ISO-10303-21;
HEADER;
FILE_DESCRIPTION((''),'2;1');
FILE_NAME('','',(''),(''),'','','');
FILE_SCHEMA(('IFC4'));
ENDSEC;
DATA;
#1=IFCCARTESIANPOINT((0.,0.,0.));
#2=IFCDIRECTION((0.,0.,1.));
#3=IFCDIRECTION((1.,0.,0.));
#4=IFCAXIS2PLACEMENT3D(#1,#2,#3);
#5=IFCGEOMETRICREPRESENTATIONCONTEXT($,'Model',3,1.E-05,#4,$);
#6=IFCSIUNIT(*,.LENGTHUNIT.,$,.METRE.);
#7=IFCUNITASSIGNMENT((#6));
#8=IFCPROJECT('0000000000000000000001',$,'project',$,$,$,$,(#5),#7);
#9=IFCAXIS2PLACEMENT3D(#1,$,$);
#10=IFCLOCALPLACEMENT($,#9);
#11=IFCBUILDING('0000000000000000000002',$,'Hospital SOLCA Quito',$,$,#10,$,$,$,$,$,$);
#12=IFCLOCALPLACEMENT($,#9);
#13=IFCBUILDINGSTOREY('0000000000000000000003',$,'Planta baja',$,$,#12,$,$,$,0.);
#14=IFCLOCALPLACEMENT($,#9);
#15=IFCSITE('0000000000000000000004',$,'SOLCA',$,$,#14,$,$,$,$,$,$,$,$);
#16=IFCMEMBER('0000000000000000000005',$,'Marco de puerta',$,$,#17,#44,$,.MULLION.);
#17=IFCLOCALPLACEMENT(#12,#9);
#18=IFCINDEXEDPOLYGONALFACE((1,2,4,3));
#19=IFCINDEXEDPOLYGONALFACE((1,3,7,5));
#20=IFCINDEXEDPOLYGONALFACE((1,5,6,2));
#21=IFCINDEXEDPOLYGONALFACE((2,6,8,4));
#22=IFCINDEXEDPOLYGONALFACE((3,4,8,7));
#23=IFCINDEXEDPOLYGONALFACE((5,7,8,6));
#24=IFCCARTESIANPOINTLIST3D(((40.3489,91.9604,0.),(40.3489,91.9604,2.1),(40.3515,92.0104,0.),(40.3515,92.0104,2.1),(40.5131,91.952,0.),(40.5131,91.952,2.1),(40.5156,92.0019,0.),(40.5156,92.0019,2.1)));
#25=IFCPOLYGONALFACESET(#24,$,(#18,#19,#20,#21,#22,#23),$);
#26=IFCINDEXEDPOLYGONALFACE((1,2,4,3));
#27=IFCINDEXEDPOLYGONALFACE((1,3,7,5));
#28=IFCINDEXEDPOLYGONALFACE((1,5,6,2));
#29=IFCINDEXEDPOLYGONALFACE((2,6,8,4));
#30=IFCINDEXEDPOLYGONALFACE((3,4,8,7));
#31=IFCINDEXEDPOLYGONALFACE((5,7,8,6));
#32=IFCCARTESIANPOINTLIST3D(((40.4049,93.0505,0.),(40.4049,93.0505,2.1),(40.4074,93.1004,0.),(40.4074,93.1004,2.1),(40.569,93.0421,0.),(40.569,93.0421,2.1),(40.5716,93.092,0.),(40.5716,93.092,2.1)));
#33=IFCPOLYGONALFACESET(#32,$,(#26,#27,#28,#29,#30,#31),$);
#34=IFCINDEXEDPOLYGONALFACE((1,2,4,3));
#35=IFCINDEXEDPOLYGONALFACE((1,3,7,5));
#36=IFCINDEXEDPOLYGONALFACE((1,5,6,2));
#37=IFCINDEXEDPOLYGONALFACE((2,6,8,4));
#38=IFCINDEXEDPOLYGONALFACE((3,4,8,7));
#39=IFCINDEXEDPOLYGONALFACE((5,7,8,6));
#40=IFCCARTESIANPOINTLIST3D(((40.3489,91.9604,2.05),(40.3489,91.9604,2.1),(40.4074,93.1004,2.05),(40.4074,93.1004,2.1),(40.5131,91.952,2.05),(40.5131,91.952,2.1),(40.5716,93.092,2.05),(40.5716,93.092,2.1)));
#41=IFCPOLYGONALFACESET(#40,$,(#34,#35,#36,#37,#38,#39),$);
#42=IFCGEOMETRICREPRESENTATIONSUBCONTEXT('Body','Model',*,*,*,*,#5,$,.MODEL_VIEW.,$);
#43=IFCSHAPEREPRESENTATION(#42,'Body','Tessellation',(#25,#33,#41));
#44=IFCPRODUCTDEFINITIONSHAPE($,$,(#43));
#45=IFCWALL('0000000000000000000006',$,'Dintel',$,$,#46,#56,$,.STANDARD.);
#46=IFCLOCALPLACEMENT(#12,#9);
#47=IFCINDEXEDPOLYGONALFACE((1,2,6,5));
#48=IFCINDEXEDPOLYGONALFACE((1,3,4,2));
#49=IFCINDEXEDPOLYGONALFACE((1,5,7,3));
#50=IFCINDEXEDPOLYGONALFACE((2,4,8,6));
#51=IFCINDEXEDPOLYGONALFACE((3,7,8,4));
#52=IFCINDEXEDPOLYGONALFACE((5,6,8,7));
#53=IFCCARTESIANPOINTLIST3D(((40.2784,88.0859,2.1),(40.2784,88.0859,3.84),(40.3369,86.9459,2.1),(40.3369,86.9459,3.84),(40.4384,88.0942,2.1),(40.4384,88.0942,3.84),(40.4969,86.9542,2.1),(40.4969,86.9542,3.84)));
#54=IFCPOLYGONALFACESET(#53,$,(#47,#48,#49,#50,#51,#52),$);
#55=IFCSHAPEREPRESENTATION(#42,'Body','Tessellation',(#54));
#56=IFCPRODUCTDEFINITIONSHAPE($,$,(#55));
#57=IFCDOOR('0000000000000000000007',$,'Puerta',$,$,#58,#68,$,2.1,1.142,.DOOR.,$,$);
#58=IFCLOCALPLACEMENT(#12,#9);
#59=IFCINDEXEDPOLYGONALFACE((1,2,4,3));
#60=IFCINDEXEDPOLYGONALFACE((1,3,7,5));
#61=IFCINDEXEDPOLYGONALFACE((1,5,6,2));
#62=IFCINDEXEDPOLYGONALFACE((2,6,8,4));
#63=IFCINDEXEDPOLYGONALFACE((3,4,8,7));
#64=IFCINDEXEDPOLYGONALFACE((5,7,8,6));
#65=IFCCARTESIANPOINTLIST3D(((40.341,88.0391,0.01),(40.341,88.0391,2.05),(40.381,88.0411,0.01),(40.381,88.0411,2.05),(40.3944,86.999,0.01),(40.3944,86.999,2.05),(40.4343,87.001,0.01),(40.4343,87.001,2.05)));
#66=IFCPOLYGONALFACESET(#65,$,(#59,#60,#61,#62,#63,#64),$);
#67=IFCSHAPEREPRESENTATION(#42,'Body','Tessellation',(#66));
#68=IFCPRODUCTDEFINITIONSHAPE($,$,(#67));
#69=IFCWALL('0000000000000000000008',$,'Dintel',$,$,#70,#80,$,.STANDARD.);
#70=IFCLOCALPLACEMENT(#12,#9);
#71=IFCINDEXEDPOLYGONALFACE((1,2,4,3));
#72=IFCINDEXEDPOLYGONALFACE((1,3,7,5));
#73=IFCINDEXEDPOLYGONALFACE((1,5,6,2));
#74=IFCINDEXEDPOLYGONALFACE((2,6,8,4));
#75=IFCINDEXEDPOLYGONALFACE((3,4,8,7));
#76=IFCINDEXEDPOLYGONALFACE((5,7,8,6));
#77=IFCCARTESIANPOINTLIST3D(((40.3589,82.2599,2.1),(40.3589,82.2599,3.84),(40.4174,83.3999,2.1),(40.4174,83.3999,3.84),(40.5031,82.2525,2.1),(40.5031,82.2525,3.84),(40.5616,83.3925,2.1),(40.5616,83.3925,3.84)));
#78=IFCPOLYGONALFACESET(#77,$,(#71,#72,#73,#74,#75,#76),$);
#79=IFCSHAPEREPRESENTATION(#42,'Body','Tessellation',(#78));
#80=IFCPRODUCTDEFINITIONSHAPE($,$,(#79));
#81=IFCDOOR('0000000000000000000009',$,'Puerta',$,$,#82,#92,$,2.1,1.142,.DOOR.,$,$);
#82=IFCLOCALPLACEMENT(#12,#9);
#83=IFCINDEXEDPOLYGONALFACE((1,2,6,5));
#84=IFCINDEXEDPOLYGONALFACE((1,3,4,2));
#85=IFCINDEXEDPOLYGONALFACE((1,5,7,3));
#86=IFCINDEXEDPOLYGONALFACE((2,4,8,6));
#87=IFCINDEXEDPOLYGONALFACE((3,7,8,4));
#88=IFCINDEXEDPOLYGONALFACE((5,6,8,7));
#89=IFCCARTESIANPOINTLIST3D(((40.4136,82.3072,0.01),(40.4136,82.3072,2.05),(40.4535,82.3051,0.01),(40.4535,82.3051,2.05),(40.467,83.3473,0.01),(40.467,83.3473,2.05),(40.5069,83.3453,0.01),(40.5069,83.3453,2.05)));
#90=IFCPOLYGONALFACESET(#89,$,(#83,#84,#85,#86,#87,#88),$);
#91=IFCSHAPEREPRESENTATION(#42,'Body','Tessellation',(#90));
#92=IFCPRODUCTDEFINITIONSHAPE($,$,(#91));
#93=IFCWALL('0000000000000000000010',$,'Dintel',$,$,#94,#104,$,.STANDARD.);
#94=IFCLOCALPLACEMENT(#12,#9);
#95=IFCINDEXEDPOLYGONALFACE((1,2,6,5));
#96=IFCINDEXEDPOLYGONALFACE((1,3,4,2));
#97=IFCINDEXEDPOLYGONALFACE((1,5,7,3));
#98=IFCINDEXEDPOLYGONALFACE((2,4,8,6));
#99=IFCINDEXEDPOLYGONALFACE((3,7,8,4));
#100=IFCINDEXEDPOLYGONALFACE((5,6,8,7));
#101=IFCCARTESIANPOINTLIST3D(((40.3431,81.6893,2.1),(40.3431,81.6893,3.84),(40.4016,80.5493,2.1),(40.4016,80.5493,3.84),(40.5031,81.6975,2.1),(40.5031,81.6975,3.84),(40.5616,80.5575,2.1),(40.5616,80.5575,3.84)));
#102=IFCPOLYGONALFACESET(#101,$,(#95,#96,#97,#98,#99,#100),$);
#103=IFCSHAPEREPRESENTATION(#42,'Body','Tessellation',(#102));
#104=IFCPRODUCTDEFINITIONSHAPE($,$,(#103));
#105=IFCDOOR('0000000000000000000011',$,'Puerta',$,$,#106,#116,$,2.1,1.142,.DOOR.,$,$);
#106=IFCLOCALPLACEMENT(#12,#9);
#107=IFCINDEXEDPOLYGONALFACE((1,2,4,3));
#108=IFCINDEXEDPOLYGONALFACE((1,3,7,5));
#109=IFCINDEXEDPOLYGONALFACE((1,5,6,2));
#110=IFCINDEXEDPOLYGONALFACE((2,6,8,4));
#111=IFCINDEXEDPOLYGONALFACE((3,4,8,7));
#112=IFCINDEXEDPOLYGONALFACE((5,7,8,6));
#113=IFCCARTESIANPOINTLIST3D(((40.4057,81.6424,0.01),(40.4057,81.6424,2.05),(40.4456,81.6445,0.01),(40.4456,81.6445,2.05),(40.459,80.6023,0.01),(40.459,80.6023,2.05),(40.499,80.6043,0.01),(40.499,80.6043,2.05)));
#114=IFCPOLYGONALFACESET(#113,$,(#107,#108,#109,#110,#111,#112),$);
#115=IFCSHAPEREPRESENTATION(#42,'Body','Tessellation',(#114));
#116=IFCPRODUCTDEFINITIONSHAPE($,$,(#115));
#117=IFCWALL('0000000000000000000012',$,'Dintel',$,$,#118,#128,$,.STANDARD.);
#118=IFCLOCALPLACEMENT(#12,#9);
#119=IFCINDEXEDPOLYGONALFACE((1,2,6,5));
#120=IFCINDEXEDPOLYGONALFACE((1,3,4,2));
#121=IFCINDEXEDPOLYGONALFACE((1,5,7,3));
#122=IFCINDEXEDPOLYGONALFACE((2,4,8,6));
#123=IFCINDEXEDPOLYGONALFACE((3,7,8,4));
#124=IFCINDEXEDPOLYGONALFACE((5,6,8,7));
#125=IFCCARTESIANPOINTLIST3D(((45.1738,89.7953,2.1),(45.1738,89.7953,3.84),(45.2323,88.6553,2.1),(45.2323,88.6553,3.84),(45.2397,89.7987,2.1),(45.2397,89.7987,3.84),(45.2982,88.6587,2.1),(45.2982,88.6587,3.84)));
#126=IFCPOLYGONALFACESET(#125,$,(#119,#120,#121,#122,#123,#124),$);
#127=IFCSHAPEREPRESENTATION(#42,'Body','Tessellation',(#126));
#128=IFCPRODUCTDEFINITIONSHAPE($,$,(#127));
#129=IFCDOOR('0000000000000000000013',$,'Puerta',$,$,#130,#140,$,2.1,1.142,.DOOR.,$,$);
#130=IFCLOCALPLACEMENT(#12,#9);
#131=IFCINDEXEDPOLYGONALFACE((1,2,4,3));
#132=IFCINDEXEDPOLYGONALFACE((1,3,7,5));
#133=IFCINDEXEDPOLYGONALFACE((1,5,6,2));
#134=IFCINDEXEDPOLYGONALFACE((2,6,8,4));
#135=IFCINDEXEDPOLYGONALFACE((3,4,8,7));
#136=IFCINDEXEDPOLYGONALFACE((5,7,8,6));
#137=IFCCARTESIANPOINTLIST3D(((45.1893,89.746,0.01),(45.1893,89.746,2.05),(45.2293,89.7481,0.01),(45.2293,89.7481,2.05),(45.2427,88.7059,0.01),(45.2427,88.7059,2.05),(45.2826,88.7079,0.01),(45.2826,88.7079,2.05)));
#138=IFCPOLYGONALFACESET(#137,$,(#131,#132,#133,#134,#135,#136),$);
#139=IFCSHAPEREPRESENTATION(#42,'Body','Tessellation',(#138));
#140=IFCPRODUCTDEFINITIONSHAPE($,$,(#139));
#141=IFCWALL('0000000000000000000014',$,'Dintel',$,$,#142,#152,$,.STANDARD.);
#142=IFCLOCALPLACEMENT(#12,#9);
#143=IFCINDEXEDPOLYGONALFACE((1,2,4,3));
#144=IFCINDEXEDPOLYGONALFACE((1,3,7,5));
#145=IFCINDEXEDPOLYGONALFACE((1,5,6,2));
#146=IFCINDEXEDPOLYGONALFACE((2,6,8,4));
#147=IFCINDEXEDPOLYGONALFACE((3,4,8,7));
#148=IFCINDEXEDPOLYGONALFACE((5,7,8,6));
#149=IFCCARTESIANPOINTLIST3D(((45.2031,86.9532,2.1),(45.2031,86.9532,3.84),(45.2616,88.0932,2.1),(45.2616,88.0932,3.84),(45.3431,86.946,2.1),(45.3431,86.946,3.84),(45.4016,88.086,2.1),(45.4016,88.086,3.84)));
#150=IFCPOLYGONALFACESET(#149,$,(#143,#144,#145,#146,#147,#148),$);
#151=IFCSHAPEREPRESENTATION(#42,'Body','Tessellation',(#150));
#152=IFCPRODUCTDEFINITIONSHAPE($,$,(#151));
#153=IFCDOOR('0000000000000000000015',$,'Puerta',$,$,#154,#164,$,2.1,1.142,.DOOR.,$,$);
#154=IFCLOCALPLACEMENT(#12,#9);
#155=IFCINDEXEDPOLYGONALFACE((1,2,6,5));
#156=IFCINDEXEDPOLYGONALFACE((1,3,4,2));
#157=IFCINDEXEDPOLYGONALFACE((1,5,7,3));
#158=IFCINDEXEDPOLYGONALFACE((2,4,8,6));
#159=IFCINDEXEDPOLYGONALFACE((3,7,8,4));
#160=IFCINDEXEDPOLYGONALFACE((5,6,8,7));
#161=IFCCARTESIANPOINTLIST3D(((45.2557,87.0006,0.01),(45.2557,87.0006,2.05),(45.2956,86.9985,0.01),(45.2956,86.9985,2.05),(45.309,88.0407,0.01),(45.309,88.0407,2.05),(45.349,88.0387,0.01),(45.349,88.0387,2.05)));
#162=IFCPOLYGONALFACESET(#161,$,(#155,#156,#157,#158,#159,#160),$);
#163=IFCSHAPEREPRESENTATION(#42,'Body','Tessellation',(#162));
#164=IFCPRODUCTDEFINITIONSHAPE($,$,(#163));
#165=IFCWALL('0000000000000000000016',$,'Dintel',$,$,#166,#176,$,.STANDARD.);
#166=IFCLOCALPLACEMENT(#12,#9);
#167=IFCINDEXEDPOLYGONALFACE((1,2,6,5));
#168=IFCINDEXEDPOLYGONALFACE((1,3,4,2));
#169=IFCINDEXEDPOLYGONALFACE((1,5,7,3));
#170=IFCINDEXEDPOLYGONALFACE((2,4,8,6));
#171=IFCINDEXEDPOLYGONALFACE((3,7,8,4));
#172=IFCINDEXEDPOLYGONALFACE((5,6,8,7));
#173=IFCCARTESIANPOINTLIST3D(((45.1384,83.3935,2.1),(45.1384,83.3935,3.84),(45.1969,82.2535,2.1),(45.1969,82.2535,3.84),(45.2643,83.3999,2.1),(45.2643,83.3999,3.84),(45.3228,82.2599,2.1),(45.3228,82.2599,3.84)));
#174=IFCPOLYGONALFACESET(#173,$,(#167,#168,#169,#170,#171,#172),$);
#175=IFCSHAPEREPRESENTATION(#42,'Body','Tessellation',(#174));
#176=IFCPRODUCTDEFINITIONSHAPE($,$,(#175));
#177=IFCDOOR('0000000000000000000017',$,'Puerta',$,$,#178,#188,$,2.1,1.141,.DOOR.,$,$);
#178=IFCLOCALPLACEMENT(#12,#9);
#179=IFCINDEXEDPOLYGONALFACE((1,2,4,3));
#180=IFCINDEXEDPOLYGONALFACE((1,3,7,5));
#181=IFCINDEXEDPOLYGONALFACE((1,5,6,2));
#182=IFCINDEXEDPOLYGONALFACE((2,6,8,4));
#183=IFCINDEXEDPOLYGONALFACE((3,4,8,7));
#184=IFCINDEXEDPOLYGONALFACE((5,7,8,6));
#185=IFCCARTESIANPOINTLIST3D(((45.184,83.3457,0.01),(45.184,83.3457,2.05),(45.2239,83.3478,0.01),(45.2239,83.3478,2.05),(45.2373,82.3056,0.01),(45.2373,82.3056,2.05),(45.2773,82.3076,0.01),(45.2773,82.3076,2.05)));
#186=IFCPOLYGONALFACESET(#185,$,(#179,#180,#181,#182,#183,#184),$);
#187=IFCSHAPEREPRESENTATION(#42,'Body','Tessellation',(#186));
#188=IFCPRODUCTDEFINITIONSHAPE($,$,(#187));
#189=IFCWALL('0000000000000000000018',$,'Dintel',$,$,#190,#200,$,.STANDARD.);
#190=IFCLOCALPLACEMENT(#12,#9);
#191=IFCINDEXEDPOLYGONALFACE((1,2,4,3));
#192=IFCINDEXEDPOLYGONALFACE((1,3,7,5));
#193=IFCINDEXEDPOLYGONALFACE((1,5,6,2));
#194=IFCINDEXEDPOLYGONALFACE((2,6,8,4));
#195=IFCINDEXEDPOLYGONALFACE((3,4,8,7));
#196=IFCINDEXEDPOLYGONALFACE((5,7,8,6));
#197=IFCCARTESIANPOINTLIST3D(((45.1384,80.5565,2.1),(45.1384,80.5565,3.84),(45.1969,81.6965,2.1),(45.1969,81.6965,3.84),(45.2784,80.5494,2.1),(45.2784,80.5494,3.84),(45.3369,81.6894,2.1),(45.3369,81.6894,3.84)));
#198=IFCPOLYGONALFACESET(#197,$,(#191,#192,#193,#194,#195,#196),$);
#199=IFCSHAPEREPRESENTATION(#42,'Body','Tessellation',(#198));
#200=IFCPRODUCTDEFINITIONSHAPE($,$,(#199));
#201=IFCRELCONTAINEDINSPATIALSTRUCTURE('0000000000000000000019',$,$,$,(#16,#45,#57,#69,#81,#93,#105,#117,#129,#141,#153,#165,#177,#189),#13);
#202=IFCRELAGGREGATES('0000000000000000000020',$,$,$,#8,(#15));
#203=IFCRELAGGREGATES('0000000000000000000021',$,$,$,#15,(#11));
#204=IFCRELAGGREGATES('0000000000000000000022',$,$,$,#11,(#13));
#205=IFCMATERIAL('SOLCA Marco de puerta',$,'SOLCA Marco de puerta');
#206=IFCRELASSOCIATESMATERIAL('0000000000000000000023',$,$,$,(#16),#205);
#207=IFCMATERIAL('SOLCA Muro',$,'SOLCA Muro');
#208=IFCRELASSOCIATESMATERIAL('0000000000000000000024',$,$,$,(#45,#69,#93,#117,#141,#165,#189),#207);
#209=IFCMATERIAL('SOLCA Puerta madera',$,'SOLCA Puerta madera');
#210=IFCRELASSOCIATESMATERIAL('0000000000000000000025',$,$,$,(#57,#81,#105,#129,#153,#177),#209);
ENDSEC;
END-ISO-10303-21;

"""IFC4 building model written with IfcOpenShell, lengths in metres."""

from ifc_helpers import new_model, si_unit, frame, origin, origin_with_axes, place, context, subcontext, project, spatial, polyline, outline, extrude, material, element, save


model = new_model("IFC4")

# Units and contexts
model_context = context("Model", 3, precision=1e-05, world=origin_with_axes())
body_context = subcontext(model_context, "Body", "Model", "MODEL_VIEW")
ifc_project = project(units=[si_unit("LENGTHUNIT", "METRE")], contexts=[model_context])

# Site, building, storey
site_placement = place(None, origin())
site = spatial("IfcSite", under=ifc_project, at=site_placement, Name="SOLCA")
building_placement = place(None, origin())
building = spatial("IfcBuilding", under=site, at=building_placement, Name="Hospital SOLCA Quito")
storey_placement = place(None, origin())
storey = spatial("IfcBuildingStorey", under=building, at=storey_placement, Name="Planta baja", Elevation=0.0)

# Member
ifc_material_1 = material(Name="SOLCA Marco de puerta", Category="SOLCA Marco de puerta")
member_1_placement = place(storey_placement, origin_with_axes())
element("IfcMember", 1, at=member_1_placement, inside=storey, material=ifc_material_1, Name="Marco de puerta", PredefinedType="MULLION", context=body_context, shape_type="SweptSolid", body=[
    extrude(outline(polyline([(40.5131, 91.952), (40.5156, 92.0019), (40.3515, 92.0104), (40.3489, 91.9604), (40.5131, 91.952)])), origin_with_axes(), (0.0, 0.0, 1.0), 2.1),
    extrude(outline(polyline([(40.569, 93.0421), (40.5716, 93.092), (40.4074, 93.1004), (40.4049, 93.0505), (40.569, 93.0421)])), origin_with_axes(), (0.0, 0.0, 1.0), 2.1),
    extrude(outline(polyline([(40.5131, 91.952), (40.5716, 93.092), (40.4074, 93.1004), (40.3489, 91.9604), (40.5131, 91.952)])), frame((0.0, 0.0, 2.05), z_axis=(0.0, 0.0, 1.0), x_axis=(1.0, 0.0, 0.0)), (0.0, 0.0, 1.0), 0.05),
])

# Wall
ifc_material_2 = material(Name="SOLCA Muro", Category="SOLCA Muro")
wall_1_placement = place(storey_placement, origin_with_axes())
element("IfcWall", 2, at=wall_1_placement, inside=storey, material=ifc_material_2, Name="Dintel", PredefinedType="STANDARD", context=body_context, shape_type="SweptSolid", body=[
    extrude(outline(polyline([(40.2784, 88.0859), (40.3369, 86.9459), (40.4969, 86.9542), (40.4384, 88.0942), (40.2784, 88.0859)])), frame((0.0, 0.0, 2.1), z_axis=(0.0, 0.0, 1.0), x_axis=(1.0, 0.0, 0.0)), (0.0, 0.0, 1.0), 1.74),
])

# Door
ifc_material_3 = material(Name="SOLCA Puerta madera", Category="SOLCA Puerta madera")
door_1_placement = place(storey_placement, origin_with_axes())
element("IfcDoor", 3, at=door_1_placement, inside=storey, material=ifc_material_3, Name="Puerta", OverallHeight=2.1, OverallWidth=1.142, PredefinedType="DOOR", context=body_context, shape_type="SweptSolid", body=[
    extrude(outline(polyline([(40.341, 88.0391), (40.3944, 86.999), (40.4343, 87.001), (40.381, 88.0411), (40.341, 88.0391)])), frame((0.0, 0.0, 0.01), z_axis=(0.0, 0.0, 1.0), x_axis=(1.0, 0.0, 0.0)), (0.0, 0.0, 1.0), 2.04),
])

# Wall
wall_2_placement = place(storey_placement, origin_with_axes())
element("IfcWall", 4, at=wall_2_placement, inside=storey, material=ifc_material_2, Name="Dintel", PredefinedType="STANDARD", context=body_context, shape_type="SweptSolid", body=[
    extrude(outline(polyline([(40.5031, 82.2525), (40.5616, 83.3925), (40.4174, 83.3999), (40.3589, 82.2599), (40.5031, 82.2525)])), frame((0.0, 0.0, 2.1), z_axis=(0.0, 0.0, 1.0), x_axis=(1.0, 0.0, 0.0)), (0.0, 0.0, 1.0), 1.74),
])

# Door
door_2_placement = place(storey_placement, origin_with_axes())
element("IfcDoor", 5, at=door_2_placement, inside=storey, material=ifc_material_3, Name="Puerta", OverallHeight=2.1, OverallWidth=1.142, PredefinedType="DOOR", context=body_context, shape_type="SweptSolid", body=[
    extrude(outline(polyline([(40.4535, 82.3051), (40.5069, 83.3453), (40.467, 83.3473), (40.4136, 82.3072), (40.4535, 82.3051)])), frame((0.0, 0.0, 0.01), z_axis=(0.0, 0.0, 1.0), x_axis=(1.0, 0.0, 0.0)), (0.0, 0.0, 1.0), 2.04),
])

# Wall
wall_3_placement = place(storey_placement, origin_with_axes())
element("IfcWall", 6, at=wall_3_placement, inside=storey, material=ifc_material_2, Name="Dintel", PredefinedType="STANDARD", context=body_context, shape_type="SweptSolid", body=[
    extrude(outline(polyline([(40.3431, 81.6893), (40.4016, 80.5493), (40.5616, 80.5575), (40.5031, 81.6975), (40.3431, 81.6893)])), frame((0.0, 0.0, 2.1), z_axis=(0.0, 0.0, 1.0), x_axis=(1.0, 0.0, 0.0)), (0.0, 0.0, 1.0), 1.74),
])

# Door
door_3_placement = place(storey_placement, origin_with_axes())
element("IfcDoor", 7, at=door_3_placement, inside=storey, material=ifc_material_3, Name="Puerta", OverallHeight=2.1, OverallWidth=1.142, PredefinedType="DOOR", context=body_context, shape_type="SweptSolid", body=[
    extrude(outline(polyline([(40.4057, 81.6424), (40.459, 80.6023), (40.499, 80.6043), (40.4456, 81.6445), (40.4057, 81.6424)])), frame((0.0, 0.0, 0.01), z_axis=(0.0, 0.0, 1.0), x_axis=(1.0, 0.0, 0.0)), (0.0, 0.0, 1.0), 2.04),
])

# Wall
wall_4_placement = place(storey_placement, origin_with_axes())
element("IfcWall", 8, at=wall_4_placement, inside=storey, material=ifc_material_2, Name="Dintel", PredefinedType="STANDARD", context=body_context, shape_type="SweptSolid", body=[
    extrude(outline(polyline([(45.2982, 88.6587), (45.2397, 89.7987), (45.1738, 89.7953), (45.2323, 88.6553), (45.2982, 88.6587)])), frame((0.0, 0.0, 2.1), z_axis=(0.0, 0.0, 1.0), x_axis=(1.0, 0.0, 0.0)), (0.0, 0.0, 1.0), 1.74),
])

# Door
door_4_placement = place(storey_placement, origin_with_axes())
element("IfcDoor", 9, at=door_4_placement, inside=storey, material=ifc_material_3, Name="Puerta", OverallHeight=2.1, OverallWidth=1.142, PredefinedType="DOOR", context=body_context, shape_type="SweptSolid", body=[
    extrude(outline(polyline([(45.2826, 88.7079), (45.2293, 89.7481), (45.1893, 89.746), (45.2427, 88.7059), (45.2826, 88.7079)])), frame((0.0, 0.0, 0.01), z_axis=(0.0, 0.0, 1.0), x_axis=(1.0, 0.0, 0.0)), (0.0, 0.0, 1.0), 2.04),
])

# Wall
wall_5_placement = place(storey_placement, origin_with_axes())
element("IfcWall", 10, at=wall_5_placement, inside=storey, material=ifc_material_2, Name="Dintel", PredefinedType="STANDARD", context=body_context, shape_type="SweptSolid", body=[
    extrude(outline(polyline([(45.2616, 88.0932), (45.2031, 86.9532), (45.3431, 86.946), (45.4016, 88.086), (45.2616, 88.0932)])), frame((0.0, 0.0, 2.1), z_axis=(0.0, 0.0, 1.0), x_axis=(1.0, 0.0, 0.0)), (0.0, 0.0, 1.0), 1.74),
])

# Door
door_5_placement = place(storey_placement, origin_with_axes())
element("IfcDoor", 11, at=door_5_placement, inside=storey, material=ifc_material_3, Name="Puerta", OverallHeight=2.1, OverallWidth=1.142, PredefinedType="DOOR", context=body_context, shape_type="SweptSolid", body=[
    extrude(outline(polyline([(45.309, 88.0407), (45.2557, 87.0006), (45.2956, 86.9985), (45.349, 88.0387), (45.309, 88.0407)])), frame((0.0, 0.0, 0.01), z_axis=(0.0, 0.0, 1.0), x_axis=(1.0, 0.0, 0.0)), (0.0, 0.0, 1.0), 2.04),
])

# Wall
wall_6_placement = place(storey_placement, origin_with_axes())
element("IfcWall", 12, at=wall_6_placement, inside=storey, material=ifc_material_2, Name="Dintel", PredefinedType="STANDARD", context=body_context, shape_type="SweptSolid", body=[
    extrude(outline(polyline([(45.3228, 82.2599), (45.2643, 83.3999), (45.1384, 83.3935), (45.1969, 82.2535), (45.3228, 82.2599)])), frame((0.0, 0.0, 2.1), z_axis=(0.0, 0.0, 1.0), x_axis=(1.0, 0.0, 0.0)), (0.0, 0.0, 1.0), 1.74),
])

# Door
door_6_placement = place(storey_placement, origin_with_axes())
element("IfcDoor", 13, at=door_6_placement, inside=storey, material=ifc_material_3, Name="Puerta", OverallHeight=2.1, OverallWidth=1.141, PredefinedType="DOOR", context=body_context, shape_type="SweptSolid", body=[
    extrude(outline(polyline([(45.2773, 82.3076), (45.2239, 83.3478), (45.184, 83.3457), (45.2373, 82.3056), (45.2773, 82.3076)])), frame((0.0, 0.0, 0.01), z_axis=(0.0, 0.0, 1.0), x_axis=(1.0, 0.0, 0.0)), (0.0, 0.0, 1.0), 2.04),
])

# Wall
wall_7_placement = place(storey_placement, origin_with_axes())
element("IfcWall", 14, at=wall_7_placement, inside=storey, material=ifc_material_2, Name="Dintel", PredefinedType="STANDARD", context=body_context, shape_type="SweptSolid", body=[
    extrude(outline(polyline([(45.1969, 81.6965), (45.1384, 80.5565), (45.2784, 80.5494), (45.3369, 81.6894), (45.1969, 81.6965)])), frame((0.0, 0.0, 2.1), z_axis=(0.0, 0.0, 1.0), x_axis=(1.0, 0.0, 0.0)), (0.0, 0.0, 1.0), 1.74),
])

save(model, "model.ifc")
